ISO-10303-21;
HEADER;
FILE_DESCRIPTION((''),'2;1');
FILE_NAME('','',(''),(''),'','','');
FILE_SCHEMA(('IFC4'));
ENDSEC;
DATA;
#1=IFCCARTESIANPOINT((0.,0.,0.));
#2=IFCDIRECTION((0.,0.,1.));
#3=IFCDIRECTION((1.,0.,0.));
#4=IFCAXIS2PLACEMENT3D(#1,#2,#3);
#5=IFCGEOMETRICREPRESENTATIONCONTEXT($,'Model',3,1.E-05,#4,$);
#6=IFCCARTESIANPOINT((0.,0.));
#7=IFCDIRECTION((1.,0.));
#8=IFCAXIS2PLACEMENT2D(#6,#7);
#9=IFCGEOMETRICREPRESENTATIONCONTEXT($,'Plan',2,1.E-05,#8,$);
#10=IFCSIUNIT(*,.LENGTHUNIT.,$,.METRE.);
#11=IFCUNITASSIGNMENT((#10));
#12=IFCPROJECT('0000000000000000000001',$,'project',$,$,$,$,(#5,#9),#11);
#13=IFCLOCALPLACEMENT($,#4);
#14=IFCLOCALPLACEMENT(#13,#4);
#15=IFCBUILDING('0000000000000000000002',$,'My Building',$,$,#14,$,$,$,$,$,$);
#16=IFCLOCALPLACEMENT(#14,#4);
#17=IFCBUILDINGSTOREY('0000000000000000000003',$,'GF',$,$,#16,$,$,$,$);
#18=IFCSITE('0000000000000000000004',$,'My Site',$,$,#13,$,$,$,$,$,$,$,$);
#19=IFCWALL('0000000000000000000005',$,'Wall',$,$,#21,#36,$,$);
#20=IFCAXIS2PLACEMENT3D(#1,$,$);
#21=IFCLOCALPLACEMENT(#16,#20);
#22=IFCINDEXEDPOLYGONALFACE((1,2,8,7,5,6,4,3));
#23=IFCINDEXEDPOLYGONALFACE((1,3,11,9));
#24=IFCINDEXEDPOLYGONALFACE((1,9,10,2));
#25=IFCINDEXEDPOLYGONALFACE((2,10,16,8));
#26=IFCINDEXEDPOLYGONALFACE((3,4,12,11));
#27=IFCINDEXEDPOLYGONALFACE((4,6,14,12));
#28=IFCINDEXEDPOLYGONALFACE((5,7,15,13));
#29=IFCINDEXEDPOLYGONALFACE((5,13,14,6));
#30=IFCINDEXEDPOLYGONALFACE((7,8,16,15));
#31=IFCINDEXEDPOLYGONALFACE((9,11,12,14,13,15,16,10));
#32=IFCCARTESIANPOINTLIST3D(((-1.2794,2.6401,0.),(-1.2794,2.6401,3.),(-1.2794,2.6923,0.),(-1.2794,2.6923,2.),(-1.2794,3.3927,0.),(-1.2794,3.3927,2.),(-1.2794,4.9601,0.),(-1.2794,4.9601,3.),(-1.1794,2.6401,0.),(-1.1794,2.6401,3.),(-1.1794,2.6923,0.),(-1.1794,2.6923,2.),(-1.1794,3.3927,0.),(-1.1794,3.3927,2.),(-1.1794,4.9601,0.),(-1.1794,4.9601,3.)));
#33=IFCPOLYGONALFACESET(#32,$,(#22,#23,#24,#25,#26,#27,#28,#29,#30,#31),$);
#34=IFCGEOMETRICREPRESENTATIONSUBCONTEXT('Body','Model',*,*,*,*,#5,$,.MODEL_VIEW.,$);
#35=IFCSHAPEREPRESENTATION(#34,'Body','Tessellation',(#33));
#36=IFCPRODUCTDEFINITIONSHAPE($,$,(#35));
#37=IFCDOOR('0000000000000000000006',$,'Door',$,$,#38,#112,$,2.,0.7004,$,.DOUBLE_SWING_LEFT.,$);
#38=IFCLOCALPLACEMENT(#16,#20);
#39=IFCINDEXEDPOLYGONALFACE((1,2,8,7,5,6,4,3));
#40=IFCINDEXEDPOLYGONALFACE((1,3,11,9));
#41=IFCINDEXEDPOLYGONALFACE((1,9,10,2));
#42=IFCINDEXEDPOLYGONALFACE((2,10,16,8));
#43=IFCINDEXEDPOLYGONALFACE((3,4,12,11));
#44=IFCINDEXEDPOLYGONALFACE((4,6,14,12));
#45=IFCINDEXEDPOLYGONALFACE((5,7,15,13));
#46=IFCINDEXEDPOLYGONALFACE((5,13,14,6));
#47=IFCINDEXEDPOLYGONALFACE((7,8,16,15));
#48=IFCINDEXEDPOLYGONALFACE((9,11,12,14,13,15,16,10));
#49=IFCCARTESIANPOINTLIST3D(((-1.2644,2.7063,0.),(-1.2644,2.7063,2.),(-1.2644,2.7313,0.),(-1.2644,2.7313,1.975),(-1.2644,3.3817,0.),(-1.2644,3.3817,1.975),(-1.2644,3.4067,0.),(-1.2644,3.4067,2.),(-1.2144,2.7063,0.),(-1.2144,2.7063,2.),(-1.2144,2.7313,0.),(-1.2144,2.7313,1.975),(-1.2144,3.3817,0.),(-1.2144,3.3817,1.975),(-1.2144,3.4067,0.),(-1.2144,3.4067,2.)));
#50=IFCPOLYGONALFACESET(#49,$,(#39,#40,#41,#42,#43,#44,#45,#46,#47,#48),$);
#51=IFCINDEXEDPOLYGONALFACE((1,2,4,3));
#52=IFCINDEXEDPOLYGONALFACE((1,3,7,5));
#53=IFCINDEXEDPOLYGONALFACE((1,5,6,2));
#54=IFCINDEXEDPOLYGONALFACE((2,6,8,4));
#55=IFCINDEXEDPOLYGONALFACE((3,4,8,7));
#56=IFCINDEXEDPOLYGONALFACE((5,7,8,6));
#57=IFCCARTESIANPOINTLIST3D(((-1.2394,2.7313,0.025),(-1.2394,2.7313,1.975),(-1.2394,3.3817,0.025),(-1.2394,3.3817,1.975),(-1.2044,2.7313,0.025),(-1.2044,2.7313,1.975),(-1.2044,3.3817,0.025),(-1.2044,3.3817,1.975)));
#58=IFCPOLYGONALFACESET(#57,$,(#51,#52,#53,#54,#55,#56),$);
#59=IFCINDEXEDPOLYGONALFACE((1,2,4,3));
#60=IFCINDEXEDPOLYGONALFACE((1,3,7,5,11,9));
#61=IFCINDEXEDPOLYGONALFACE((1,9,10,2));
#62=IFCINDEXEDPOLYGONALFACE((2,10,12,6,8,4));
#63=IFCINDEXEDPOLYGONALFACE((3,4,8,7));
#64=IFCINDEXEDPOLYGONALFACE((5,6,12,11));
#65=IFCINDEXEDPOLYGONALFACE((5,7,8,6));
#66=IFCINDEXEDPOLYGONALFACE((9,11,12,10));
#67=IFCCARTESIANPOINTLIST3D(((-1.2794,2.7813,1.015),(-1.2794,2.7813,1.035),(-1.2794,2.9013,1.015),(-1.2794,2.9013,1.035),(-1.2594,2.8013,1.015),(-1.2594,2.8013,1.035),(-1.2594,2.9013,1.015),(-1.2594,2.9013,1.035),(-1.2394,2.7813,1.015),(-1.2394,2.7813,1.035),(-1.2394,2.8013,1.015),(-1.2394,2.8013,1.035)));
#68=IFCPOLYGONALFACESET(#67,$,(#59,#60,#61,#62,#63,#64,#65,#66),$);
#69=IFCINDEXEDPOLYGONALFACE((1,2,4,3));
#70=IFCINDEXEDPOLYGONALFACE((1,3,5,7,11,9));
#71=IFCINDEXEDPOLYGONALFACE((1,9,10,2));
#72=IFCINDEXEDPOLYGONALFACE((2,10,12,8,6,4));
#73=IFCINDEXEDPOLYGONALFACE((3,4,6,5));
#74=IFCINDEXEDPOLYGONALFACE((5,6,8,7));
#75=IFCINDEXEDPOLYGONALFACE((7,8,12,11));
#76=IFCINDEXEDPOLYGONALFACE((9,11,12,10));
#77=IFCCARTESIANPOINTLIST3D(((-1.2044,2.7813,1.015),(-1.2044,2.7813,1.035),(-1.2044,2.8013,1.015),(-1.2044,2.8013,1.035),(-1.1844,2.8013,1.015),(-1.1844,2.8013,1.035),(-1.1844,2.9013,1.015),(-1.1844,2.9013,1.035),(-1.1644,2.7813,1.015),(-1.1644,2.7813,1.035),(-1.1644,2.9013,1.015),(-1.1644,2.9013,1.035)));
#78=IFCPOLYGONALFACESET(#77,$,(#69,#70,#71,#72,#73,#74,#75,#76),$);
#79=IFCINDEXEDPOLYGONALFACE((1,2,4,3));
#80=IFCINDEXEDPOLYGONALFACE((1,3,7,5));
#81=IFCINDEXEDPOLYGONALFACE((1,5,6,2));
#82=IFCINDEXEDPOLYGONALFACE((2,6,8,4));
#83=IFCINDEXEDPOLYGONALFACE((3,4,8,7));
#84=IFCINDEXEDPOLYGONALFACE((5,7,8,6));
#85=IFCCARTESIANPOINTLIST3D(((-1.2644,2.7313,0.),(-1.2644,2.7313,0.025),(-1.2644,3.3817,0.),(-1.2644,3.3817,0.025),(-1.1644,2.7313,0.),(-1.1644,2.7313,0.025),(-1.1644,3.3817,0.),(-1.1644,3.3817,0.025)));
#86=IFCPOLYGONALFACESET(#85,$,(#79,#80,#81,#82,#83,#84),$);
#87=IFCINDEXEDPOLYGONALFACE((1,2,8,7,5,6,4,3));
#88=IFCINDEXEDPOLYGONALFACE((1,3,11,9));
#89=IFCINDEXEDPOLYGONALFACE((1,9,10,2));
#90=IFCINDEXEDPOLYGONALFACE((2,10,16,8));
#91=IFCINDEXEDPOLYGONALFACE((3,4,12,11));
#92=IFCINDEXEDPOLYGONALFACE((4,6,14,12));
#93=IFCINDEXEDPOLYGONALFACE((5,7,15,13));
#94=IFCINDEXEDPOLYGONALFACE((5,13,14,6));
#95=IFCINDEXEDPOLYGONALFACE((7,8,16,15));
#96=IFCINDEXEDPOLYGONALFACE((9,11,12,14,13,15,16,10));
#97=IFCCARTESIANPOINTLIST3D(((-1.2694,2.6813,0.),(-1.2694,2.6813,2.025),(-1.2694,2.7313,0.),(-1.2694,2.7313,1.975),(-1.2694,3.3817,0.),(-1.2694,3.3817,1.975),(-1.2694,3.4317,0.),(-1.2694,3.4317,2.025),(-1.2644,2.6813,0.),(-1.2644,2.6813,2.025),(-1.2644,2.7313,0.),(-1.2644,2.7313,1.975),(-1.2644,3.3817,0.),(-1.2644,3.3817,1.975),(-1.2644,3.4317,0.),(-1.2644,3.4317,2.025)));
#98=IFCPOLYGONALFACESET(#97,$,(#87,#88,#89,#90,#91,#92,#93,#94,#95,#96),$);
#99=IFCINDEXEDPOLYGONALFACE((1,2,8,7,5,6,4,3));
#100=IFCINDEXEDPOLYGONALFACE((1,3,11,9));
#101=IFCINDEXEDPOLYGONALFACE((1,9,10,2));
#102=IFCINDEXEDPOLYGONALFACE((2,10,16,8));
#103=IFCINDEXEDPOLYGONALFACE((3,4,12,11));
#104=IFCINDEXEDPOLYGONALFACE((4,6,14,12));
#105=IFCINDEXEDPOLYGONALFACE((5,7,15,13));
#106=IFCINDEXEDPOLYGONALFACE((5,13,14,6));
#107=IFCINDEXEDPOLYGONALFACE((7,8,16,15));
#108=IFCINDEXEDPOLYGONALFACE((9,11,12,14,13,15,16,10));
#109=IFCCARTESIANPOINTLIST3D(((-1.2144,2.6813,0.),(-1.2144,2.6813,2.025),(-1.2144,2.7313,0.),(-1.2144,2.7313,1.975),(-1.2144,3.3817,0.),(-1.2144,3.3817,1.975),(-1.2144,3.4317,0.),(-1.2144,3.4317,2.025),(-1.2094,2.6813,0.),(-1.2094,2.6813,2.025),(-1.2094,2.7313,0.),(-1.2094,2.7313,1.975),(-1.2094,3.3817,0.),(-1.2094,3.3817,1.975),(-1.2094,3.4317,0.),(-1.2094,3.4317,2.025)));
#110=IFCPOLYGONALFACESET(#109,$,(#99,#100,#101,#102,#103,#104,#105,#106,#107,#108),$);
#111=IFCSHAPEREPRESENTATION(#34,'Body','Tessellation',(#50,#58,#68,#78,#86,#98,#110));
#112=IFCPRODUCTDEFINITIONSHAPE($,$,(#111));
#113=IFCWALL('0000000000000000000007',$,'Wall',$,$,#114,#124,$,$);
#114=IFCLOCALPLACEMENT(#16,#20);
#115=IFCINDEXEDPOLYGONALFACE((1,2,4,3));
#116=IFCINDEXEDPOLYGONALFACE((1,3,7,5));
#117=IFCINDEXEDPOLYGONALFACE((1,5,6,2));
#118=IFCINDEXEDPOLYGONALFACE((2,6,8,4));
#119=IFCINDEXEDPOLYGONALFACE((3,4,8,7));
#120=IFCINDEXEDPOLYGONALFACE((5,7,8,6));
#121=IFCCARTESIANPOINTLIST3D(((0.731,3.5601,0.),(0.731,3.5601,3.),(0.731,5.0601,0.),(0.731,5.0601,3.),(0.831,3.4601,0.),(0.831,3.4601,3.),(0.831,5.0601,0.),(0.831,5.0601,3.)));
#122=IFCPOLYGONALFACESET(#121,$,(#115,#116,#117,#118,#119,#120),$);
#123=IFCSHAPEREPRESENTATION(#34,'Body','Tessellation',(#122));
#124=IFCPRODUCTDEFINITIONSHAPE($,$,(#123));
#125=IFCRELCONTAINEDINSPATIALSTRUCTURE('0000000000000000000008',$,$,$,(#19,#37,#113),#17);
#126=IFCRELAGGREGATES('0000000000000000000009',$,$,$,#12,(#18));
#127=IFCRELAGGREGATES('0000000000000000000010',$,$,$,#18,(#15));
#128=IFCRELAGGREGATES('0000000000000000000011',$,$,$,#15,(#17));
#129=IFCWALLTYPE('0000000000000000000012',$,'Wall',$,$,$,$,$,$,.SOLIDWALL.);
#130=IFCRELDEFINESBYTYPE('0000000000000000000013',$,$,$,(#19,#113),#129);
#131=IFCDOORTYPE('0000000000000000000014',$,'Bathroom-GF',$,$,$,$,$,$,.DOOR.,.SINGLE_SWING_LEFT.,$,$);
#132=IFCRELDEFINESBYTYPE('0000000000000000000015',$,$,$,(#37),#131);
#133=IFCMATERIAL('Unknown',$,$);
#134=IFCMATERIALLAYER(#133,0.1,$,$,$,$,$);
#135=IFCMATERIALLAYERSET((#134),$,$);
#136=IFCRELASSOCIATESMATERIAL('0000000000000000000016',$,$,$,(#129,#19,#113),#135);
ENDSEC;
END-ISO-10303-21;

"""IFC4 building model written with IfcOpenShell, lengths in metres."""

from ifc_helpers import new_model, entity, si_unit, frame, origin_with_axes, origin_2d_with_axis, place, context, subcontext, project, spatial, line, indexed_curve, outline, extrude, shape, source, transform, mapped, material, layer, layer_set, layer_usage, type_object, type_shapes, element, fill, save


model = new_model("IFC4")

# Units and contexts
model_context = context("Model", 3, precision=1e-05, world=origin_with_axes())
plan_context = context("Plan", 2, precision=1e-05, world=origin_2d_with_axis())
body_context_1 = subcontext(model_context, "Body", "Model", "MODEL_VIEW")
body_context_2 = subcontext(plan_context, "Body", "Plan", "PLAN_VIEW")
ifc_project = project(units=[si_unit("LENGTHUNIT", "METRE")], contexts=[model_context, plan_context])

# Site, building, storey
site_placement = place(None, origin_with_axes())
site = spatial("IfcSite", under=ifc_project, at=site_placement, Name="My Site")
building_placement = place(site_placement, origin_with_axes())
building = spatial("IfcBuilding", under=site, at=building_placement, Name="My Building")
storey_placement = place(building_placement, origin_with_axes())
storey = spatial("IfcBuildingStorey", under=building, at=storey_placement, Name="GF")

# Shared definitions
ifc_material_1 = material(Name="Unknown")

# Shared definitions
ifc_layer_1 = layer(ifc_material_1, 0.1)
ifc_layer_set_1 = layer_set([ifc_layer_1])
wall_type = type_object("IfcWallType", Name="Wall", PredefinedType="SOLIDWALL", material=ifc_layer_set_1)

# Wall, opening, door
ifc_layer_usage_1 = layer_usage(ifc_layer_set_1, "AXIS2", "POSITIVE", 0.0)
wall_1_placement = place(storey_placement, frame((-1.1794, 2.6401, 0.0), z_axis=(0.0, 0.0, 1.0), x_axis=(0.0, 1.0, 0.0)))
wall_1 = element("IfcWall", 1, at=wall_1_placement, inside=storey, type_object=wall_type, material=ifc_layer_usage_1, Name="Wall", context=body_context_1, shape_type="SweptSolid", body=[
    extrude(outline(indexed_curve([(0.0, 0.0), (0.0, 0.1), (2.32, 0.1), (2.32, 0.0)], segments=[line(1, 2, 3, 4, 1)])), origin_with_axes(), (0.0, 0.0, 1.0), 3.0),
])
shared_shape_1 = source(origin_with_axes(), body_context_1, "Body", "SweptSolid", [
    extrude(outline(indexed_curve([(0.0, 0.0), (0.7004, 0.0), (0.7004, 2.0), (0.0, 2.0)], segments=[line(1, 2, 3, 4, 1)])), frame((0.0, -0.6, 0.0), z_axis=(0.0, -1.0, 0.0), x_axis=(1.0, 0.0, 0.0)), (0.0, 0.0, -1.0), 1.2),
])
opening_1_placement = place(wall_1_placement, frame((0.0522, 0.0, 0.0), z_axis=(0.0, 0.0, 1.0), x_axis=(1.0, 0.0, 0.0)))
opening_1 = element("IfcOpeningElement", 2, at=opening_1_placement, cuts=wall_1, PredefinedType="OPENING", context=body_context_1, shape_type="MappedRepresentation", body=[
    mapped(shared_shape_1, transform((0.0, 0.0, 0.0), x_axis=(1.0, 0.0, 0.0), y_axis=(0.0, 1.0, 0.0), z_axis=(0.0, 0.0, 1.0), scale=1.0)),
])
door_type_1 = type_object("IfcDoorType", Name="Bathroom-GF", OperationType="SINGLE_SWING_LEFT", PredefinedType="DOOR")
shared_shape_2 = source(origin_with_axes(), body_context_1, "Body", "SweptSolid", [
    extrude(outline(indexed_curve([(0.0, 0.0), (0.0, 2.0), (0.7004, 2.0), (0.7004, 0.0), (0.6754, 0.0), (0.6754, 1.975), (0.025, 1.975), (0.025, 0.0)], segments=[line(1, 2, 3, 4, 5, 6, 7, 8, 1)])), frame((0.0, 0.0, 0.0), z_axis=(0.0, -1.0, 0.0), x_axis=(1.0, 0.0, 0.0)), (0.0, 0.0, -1.0), 0.05),
    extrude(outline(indexed_curve([(0.0, 0.0), (0.6504, 0.0), (0.6504, 0.035), (0.0, 0.035)], segments=[line(1, 2, 3, 4, 1)])), frame((0.025, 0.025, 0.025), z_axis=(0.0, 0.0, 1.0), x_axis=(1.0, 0.0, 0.0)), (0.0, 0.0, 1.0), 1.95),
    extrude(outline(indexed_curve([(0.0, 0.0), (0.0, -0.04), (-0.12, -0.04), (-0.12, -0.02), (-0.02, -0.02), (-0.02, 0.0)], segments=[line(1, 2, 3, 4, 5, 6, 1)])), frame((0.6254, 0.025, 1.015), z_axis=(0.0, 0.0, 1.0), x_axis=(1.0, 0.0, 0.0)), (0.0, 0.0, 1.0), 0.02),
    extrude(outline(indexed_curve([(0.0, 0.0), (0.0, 0.04), (-0.12, 0.04), (-0.12, 0.02), (-0.02, 0.02), (-0.02, 0.0)], segments=[line(1, 2, 3, 4, 5, 6, 1)])), frame((0.6254, 0.06, 1.015), z_axis=(0.0, 0.0, 1.0), x_axis=(1.0, 0.0, 0.0)), (0.0, 0.0, 1.0), 0.02),
    extrude(outline(indexed_curve([(0.0, 0.0), (0.6504, 0.0), (0.6504, 0.1), (0.0, 0.1)], segments=[line(1, 2, 3, 4, 1)])), frame((0.025, 0.0, 0.0), z_axis=(0.0, 0.0, 1.0), x_axis=(1.0, 0.0, 0.0)), (0.0, 0.0, 1.0), 0.025),
    extrude(outline(indexed_curve([(0.0, 0.0), (0.0, 2.025), (0.7504, 2.025), (0.7504, 0.0), (0.7004, 0.0), (0.7004, 1.975), (0.05, 1.975), (0.05, 0.0)], segments=[line(1, 2, 3, 4, 5, 6, 7, 8, 1)])), frame((-0.025, -0.005, 0.0), z_axis=(0.0, -1.0, 0.0), x_axis=(1.0, 0.0, 0.0)), (0.0, 0.0, -1.0), 0.005),
    extrude(outline(indexed_curve([(0.0, 0.0), (0.0, 2.025), (0.7504, 2.025), (0.7504, 0.0), (0.7004, 0.0), (0.7004, 1.975), (0.05, 1.975), (0.05, 0.0)], segments=[line(1, 2, 3, 4, 5, 6, 7, 8, 1)])), frame((-0.025, 0.05, 0.0), z_axis=(0.0, -1.0, 0.0), x_axis=(1.0, 0.0, 0.0)), (0.0, 0.0, -1.0), 0.005),
])
shared_shape_3 = source(origin_with_axes(), body_context_2, "Body", "Curve2D", [
    entity("IfcIndexedPolyCurve", entity("IfcCartesianPointList2D", [[0.0, 0.0], [0.025, 0.0], [0.025, 0.05], [0.0, 0.05]]), [entity("IfcLineIndex", [1, 2, 3, 4, 1])]),
    entity("IfcIndexedPolyCurve", entity("IfcCartesianPointList2D", [[0.7004, 0.0], [0.6754, 0.0], [0.6754, 0.05], [0.7004, 0.05]]), [entity("IfcLineIndex", [1, 2, 3, 4, 1])]),
    entity("IfcIndexedPolyCurve", entity("IfcCartesianPointList2D", [[0.025, 0.05], [0.025, -0.6004], [0.06, -0.6004]])),
    entity("IfcTrimmedCurve", entity("IfcEllipse", entity("IfcAxis2Placement2D", entity("IfcCartesianPoint", [0.06, 0.05]), entity("IfcDirection", [1.0, 0.0])), 0.6154, 0.6504), [entity("IfcCartesianPoint", [0.06, -0.6004])], [entity("IfcCartesianPoint", [0.06, 0.7004])], True, "CARTESIAN"),
    entity("IfcIndexedPolyCurve", entity("IfcCartesianPointList2D", [[0.025, 0.05], [0.06, 0.05], [0.06, 0.7004], [0.025, 0.7004]]), [entity("IfcLineIndex", [1, 2, 3, 4, 1])]),
])
type_shapes(door_type_1, [shared_shape_2, shared_shape_3])
door_1_placement = place(opening_1_placement, frame((0.7144, 0.085, 0.0), z_axis=(0.0, 0.0, 1.0), x_axis=(-1.0, 0.0, 0.0)))
door_1 = element("IfcDoor", 3, at=door_1_placement, inside=storey, type_object=door_type_1, Name="Door", OperationType="DOUBLE_SWING_LEFT", OverallHeight=2.0, OverallWidth=0.7004, shapes=[
    shape(body_context_1, "Body", "MappedRepresentation", [mapped(shared_shape_2, transform((0.0, 0.0, 0.0), x_axis=(1.0, 0.0, 0.0), y_axis=(0.0, 1.0, 0.0), z_axis=(0.0, 0.0, 1.0), scale=1.0))]),
    shape(body_context_2, "Body", "MappedRepresentation", [mapped(shared_shape_3, transform((0.0, 0.0, 0.0), x_axis=(1.0, 0.0, 0.0), y_axis=(0.0, 1.0, 0.0), z_axis=(0.0, 0.0, 1.0), scale=1.0))]),
])
fill(opening_1, door_1)

# Wall
ifc_layer_usage_2 = layer_usage(ifc_layer_set_1, "AXIS2", "POSITIVE", 0.0)
wall_2_placement = place(storey_placement, frame((0.731, 5.0601, 0.0), z_axis=(0.0, 0.0, 1.0), x_axis=(0.0, -1.0, 0.0)))
element("IfcWall", 4, at=wall_2_placement, inside=storey, type_object=wall_type, material=ifc_layer_usage_2, Name="Wall", context=body_context_1, shape_type="SweptSolid", body=[
    extrude(outline(indexed_curve([(0.0, 0.0), (0.0, 0.1), (1.6, 0.1), (1.5, 0.0)], segments=[line(1, 2, 3, 4, 1)])), origin_with_axes(), (0.0, 0.0, 1.0), 3.0),
])

save(model, "model.ifc")
